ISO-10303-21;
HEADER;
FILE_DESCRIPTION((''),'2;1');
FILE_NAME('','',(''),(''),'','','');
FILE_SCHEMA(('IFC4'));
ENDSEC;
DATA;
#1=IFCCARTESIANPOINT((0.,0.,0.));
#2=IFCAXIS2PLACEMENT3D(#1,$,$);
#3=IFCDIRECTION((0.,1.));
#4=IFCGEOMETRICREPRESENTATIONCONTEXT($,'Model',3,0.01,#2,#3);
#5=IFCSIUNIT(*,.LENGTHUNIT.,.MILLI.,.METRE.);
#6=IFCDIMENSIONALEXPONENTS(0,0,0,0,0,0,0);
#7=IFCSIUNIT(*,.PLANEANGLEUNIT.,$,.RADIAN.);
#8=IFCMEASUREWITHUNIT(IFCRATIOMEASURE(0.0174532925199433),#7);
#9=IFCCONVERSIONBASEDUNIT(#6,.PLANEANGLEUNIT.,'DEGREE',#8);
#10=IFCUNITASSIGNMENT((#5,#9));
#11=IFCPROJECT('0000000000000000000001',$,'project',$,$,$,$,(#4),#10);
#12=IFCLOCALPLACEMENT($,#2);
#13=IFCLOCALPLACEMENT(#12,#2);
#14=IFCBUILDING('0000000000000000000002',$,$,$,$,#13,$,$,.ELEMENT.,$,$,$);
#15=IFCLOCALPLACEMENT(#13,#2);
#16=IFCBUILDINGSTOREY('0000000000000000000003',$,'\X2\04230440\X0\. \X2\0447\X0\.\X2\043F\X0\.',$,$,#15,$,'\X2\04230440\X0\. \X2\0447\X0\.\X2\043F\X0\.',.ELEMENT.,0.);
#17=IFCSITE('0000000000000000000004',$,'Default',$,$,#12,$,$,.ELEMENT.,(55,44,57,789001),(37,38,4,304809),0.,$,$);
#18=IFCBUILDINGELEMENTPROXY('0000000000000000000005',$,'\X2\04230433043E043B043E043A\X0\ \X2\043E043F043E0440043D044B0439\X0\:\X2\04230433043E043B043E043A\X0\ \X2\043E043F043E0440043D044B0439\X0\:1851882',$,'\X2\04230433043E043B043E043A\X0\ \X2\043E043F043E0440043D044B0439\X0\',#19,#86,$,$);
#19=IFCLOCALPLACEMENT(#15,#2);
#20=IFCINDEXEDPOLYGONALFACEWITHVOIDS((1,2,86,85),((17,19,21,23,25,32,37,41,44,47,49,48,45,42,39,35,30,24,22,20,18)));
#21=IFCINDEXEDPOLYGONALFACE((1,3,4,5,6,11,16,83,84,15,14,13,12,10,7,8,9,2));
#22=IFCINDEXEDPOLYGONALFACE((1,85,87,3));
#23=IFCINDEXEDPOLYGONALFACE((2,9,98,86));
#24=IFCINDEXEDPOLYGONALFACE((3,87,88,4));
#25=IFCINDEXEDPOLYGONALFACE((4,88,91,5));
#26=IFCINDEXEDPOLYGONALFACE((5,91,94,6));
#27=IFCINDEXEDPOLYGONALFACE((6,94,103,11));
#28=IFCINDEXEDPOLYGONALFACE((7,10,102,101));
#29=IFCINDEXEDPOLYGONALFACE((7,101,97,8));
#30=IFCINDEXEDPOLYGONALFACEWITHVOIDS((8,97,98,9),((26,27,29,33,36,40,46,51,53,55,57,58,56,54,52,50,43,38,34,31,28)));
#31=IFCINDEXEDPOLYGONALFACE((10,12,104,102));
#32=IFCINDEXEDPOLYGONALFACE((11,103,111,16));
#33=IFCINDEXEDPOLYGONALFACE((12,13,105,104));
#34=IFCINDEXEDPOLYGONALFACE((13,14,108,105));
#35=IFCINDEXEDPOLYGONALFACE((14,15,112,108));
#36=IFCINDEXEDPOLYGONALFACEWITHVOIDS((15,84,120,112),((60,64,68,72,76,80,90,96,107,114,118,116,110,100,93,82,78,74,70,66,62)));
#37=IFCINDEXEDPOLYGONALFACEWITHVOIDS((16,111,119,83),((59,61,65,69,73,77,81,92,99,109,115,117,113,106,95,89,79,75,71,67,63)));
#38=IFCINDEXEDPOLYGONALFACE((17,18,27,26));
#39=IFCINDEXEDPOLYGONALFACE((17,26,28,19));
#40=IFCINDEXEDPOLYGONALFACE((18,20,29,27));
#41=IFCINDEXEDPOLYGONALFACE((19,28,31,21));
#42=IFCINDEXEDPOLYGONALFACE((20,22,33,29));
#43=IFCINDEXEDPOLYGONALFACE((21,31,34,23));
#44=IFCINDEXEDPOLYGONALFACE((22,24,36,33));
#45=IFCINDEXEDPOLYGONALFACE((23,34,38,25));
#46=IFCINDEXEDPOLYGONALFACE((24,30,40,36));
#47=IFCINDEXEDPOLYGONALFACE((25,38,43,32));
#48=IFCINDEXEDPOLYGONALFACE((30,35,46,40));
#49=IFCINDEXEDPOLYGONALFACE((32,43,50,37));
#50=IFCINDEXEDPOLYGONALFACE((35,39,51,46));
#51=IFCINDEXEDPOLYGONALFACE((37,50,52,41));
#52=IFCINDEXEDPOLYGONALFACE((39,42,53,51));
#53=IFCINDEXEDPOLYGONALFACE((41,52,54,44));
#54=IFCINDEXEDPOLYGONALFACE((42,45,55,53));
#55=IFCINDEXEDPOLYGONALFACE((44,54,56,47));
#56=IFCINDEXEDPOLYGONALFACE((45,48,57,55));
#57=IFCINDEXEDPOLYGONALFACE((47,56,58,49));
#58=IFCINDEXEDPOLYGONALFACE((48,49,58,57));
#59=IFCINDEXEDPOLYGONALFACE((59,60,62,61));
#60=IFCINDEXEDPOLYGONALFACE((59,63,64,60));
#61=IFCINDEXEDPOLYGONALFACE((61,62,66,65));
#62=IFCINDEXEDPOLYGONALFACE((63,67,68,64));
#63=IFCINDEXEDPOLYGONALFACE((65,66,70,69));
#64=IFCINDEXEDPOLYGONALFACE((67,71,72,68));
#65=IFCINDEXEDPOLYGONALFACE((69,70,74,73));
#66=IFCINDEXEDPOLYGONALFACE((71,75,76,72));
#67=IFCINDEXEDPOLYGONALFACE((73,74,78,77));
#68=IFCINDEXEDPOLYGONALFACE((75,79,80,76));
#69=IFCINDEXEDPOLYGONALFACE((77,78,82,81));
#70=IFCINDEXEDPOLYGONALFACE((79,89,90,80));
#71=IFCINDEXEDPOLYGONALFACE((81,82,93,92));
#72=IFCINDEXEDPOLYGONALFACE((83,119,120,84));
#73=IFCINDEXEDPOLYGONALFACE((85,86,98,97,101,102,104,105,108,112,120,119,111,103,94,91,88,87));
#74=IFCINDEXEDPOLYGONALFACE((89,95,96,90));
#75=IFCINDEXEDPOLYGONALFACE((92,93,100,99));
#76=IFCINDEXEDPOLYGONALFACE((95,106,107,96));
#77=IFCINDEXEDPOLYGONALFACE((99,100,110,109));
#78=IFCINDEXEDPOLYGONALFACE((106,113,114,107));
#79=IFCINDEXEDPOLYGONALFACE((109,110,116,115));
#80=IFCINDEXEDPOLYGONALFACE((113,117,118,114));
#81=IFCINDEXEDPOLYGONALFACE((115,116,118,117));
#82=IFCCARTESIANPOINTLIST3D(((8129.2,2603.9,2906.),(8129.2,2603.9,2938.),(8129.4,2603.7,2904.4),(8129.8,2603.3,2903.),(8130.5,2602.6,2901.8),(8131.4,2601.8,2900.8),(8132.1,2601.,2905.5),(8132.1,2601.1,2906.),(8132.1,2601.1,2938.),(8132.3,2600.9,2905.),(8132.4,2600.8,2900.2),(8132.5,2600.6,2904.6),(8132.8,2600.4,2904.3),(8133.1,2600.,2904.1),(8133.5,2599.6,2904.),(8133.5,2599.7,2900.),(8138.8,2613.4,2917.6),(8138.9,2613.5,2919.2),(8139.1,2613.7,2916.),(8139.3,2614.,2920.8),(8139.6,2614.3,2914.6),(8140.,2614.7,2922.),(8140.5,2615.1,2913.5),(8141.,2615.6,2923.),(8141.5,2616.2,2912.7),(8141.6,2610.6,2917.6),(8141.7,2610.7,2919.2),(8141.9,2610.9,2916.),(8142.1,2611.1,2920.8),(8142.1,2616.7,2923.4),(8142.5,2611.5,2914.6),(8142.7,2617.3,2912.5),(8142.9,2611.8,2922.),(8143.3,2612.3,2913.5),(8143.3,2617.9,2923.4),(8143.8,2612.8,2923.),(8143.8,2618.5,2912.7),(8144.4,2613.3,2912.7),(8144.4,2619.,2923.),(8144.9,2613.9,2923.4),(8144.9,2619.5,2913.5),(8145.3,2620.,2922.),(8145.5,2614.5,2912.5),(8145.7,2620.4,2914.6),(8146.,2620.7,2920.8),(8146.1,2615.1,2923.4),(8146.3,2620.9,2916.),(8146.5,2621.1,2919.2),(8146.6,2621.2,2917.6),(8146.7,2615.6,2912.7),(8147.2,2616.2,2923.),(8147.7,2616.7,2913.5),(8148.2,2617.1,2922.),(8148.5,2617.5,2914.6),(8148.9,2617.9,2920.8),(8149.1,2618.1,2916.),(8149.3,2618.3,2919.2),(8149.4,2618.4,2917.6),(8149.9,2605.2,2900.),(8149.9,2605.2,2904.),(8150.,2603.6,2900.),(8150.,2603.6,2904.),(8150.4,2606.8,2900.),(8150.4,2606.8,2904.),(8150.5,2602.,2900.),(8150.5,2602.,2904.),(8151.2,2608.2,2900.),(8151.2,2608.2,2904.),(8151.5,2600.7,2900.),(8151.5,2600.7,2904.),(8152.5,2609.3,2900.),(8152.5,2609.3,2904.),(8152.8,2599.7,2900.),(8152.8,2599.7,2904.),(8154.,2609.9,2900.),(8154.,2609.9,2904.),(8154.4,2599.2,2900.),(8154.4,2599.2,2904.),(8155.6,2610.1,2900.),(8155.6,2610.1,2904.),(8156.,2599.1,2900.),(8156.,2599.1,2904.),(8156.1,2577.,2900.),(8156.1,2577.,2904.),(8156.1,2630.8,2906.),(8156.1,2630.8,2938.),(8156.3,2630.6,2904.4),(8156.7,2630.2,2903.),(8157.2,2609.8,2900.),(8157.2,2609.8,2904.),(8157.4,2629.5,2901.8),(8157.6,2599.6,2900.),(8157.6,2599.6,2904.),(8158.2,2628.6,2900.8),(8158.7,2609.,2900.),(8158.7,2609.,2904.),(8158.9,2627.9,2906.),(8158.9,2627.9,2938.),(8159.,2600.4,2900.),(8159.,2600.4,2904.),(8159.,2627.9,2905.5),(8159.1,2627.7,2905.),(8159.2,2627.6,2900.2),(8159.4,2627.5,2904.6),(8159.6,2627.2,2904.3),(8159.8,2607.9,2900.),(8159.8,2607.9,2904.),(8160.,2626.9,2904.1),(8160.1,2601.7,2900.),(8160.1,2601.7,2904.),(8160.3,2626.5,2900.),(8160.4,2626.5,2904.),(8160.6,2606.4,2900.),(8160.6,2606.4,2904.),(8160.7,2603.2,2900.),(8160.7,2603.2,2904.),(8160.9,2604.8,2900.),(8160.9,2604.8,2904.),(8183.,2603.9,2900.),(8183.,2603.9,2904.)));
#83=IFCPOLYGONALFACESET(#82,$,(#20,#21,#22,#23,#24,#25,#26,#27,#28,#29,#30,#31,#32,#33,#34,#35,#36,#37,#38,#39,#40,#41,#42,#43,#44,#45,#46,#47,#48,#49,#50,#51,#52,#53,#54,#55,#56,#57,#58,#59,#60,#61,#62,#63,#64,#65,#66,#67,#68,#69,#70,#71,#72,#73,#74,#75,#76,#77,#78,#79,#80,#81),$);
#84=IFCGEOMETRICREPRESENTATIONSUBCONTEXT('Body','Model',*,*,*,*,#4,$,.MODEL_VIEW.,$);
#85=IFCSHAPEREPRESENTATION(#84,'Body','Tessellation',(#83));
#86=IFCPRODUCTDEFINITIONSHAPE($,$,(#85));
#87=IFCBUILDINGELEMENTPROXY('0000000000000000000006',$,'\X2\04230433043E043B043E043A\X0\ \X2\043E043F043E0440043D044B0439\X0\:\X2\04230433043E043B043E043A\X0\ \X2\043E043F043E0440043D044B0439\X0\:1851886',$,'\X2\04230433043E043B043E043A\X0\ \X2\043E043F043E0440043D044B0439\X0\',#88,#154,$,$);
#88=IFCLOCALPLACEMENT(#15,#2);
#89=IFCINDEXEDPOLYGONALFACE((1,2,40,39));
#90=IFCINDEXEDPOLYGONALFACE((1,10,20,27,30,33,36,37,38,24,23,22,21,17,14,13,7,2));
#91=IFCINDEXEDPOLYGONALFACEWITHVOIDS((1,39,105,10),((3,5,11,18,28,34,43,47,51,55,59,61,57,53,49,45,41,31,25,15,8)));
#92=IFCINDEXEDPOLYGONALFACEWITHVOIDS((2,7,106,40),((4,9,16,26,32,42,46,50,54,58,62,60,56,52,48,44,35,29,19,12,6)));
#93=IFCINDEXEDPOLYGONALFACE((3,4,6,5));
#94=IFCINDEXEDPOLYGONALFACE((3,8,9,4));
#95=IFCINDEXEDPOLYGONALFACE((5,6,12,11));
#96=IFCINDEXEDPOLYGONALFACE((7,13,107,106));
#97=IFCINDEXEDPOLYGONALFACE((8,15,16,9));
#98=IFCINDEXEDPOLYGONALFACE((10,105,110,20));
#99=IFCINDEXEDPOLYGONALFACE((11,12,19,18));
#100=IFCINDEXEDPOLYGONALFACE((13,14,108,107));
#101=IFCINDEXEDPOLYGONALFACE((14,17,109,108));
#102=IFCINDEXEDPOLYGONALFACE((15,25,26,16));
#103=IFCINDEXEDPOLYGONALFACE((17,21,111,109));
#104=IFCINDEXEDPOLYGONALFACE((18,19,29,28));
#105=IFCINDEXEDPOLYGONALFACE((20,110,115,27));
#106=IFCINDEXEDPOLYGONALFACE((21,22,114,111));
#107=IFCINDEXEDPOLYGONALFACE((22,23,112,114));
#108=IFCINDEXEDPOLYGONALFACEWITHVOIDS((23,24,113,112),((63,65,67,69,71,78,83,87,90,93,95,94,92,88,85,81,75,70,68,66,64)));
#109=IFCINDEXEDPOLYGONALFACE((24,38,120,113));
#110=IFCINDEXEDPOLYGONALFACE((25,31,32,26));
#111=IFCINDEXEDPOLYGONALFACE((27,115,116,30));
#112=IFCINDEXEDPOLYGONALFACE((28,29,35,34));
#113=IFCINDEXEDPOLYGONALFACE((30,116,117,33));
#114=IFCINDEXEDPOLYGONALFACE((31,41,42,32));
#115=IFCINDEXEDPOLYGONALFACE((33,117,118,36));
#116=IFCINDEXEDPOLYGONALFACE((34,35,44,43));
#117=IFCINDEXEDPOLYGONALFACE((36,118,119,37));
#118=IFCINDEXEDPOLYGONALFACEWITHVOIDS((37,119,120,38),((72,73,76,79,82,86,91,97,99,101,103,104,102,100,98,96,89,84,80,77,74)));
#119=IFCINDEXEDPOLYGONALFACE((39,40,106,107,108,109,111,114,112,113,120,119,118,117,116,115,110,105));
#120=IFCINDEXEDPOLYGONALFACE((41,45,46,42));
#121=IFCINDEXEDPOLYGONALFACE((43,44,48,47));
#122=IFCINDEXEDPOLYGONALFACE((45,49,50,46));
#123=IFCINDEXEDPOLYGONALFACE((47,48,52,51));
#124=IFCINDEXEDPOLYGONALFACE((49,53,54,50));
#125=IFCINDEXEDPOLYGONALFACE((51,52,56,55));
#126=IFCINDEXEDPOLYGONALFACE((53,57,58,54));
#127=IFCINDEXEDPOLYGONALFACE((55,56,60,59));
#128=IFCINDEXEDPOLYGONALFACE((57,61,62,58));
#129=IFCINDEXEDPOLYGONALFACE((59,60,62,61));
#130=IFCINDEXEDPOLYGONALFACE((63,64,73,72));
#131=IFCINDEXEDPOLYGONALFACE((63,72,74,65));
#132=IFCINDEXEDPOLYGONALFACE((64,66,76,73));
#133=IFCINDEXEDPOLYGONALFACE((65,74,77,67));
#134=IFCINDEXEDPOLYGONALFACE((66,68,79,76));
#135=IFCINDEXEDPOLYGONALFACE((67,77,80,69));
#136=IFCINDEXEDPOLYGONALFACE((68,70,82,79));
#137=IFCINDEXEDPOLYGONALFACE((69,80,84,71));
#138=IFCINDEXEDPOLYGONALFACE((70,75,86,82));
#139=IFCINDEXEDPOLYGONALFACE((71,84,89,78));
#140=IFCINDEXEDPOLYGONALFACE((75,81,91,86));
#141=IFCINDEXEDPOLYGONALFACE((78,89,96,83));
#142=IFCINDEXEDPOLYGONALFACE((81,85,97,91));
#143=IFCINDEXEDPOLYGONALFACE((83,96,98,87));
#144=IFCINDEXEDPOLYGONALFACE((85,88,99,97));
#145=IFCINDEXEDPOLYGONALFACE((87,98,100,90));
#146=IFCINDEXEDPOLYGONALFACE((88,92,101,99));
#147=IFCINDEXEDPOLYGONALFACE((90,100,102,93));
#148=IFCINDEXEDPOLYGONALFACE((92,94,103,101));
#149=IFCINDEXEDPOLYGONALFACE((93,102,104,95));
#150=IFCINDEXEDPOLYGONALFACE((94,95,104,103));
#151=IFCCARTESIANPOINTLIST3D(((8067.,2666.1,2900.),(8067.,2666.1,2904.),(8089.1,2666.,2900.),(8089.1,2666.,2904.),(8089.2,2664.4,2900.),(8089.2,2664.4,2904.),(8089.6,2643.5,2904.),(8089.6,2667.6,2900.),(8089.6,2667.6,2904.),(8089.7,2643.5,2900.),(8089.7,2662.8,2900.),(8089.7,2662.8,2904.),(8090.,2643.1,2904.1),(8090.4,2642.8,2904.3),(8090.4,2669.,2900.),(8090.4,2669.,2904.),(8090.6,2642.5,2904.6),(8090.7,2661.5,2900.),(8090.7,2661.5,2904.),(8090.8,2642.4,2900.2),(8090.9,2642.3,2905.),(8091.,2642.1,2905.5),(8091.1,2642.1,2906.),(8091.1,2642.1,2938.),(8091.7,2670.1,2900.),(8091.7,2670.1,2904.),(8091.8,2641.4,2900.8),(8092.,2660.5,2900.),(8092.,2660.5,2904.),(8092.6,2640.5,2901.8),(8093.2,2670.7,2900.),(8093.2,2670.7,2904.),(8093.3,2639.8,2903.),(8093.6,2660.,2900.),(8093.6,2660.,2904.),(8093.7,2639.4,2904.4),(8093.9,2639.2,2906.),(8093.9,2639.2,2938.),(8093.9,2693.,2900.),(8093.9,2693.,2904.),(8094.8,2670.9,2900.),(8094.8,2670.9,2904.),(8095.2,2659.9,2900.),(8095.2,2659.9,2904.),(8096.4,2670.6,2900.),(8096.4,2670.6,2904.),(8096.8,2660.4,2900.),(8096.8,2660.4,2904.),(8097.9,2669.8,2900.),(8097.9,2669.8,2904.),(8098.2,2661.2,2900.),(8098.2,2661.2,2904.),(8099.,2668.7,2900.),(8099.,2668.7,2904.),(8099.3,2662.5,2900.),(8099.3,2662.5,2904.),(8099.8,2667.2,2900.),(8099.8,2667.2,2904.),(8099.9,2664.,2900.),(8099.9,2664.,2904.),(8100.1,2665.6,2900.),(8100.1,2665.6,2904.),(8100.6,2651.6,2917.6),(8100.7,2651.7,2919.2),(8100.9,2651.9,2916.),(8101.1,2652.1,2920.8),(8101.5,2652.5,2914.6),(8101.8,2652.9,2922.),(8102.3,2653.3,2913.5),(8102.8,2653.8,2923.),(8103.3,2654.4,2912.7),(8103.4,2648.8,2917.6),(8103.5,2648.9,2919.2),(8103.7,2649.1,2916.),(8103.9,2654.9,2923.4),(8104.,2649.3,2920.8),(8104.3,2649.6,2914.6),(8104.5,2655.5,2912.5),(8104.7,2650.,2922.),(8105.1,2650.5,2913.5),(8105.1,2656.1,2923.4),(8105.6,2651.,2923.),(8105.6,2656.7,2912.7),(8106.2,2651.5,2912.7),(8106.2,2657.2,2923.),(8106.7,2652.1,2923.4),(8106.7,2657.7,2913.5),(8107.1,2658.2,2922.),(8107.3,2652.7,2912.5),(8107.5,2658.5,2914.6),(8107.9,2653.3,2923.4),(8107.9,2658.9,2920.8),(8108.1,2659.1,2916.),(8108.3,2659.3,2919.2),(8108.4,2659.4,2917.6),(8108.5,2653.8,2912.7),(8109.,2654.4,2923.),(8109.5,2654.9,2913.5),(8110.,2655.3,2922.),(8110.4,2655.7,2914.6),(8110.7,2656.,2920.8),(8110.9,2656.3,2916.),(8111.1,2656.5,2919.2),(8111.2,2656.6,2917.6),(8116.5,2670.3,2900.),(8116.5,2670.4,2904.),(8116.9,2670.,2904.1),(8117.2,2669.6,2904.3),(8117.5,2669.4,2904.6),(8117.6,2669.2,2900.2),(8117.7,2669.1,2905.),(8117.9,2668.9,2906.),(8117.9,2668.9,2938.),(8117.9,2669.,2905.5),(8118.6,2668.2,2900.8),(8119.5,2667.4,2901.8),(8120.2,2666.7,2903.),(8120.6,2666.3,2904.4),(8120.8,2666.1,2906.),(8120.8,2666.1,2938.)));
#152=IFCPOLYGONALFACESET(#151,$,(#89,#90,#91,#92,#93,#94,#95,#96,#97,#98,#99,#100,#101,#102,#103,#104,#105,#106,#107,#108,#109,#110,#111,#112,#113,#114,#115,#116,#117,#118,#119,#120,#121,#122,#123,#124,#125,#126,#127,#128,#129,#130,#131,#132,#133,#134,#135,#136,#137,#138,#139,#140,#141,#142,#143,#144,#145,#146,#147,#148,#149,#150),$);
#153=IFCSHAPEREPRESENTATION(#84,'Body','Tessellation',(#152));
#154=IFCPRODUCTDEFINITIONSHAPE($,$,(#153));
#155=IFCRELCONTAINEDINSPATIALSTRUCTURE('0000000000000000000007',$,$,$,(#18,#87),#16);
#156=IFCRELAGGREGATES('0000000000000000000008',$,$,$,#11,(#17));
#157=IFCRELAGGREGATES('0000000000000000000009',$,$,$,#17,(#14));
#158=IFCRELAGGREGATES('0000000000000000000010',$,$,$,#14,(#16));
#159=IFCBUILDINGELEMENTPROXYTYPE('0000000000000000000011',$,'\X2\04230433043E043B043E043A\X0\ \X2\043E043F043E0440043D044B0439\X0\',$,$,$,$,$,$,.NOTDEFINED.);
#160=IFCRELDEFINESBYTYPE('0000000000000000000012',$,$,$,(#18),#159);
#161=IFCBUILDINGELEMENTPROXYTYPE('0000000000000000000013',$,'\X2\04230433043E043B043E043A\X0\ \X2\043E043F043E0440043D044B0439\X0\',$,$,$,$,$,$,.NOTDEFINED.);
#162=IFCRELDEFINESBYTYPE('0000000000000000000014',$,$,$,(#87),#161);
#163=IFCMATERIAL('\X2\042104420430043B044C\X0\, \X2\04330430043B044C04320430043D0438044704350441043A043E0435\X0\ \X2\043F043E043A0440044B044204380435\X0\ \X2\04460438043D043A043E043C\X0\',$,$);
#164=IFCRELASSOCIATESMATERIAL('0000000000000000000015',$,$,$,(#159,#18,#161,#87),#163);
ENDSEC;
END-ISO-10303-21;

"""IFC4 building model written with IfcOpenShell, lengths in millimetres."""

from ifc_helpers import new_model, entity, si_unit, converted_unit, direction, frame, frame_2d, origin, place, context, subcontext, project, spatial, polyline, circle_curve, parameter, trimmed, segment, composite_curve, circle, outline, extrude, source, transform, mapped, material, type_object, type_shapes, element, save


model = new_model("IFC4")

# Units and contexts
model_context = context("Model", 3, precision=0.01, world=origin(), true_north=direction((0.0, 1.0)))
body_context = subcontext(model_context, "Body", "Model", "MODEL_VIEW")
ifc_project = project(units=[si_unit("LENGTHUNIT", "METRE", prefix="MILLI"), converted_unit("PLANEANGLEUNIT", "DEGREE", entity("IfcRatioMeasure", 0.0174532925199433), si_unit("PLANEANGLEUNIT", "RADIAN"), dimensions=[0, 0, 0, 0, 0, 0, 0])], contexts=[model_context])

# Site, building, storey
site_placement = place(None, origin())
site = spatial("IfcSite", under=ifc_project, at=site_placement, Name="Default", CompositionType="ELEMENT", RefLatitude=(55, 44, 57, 789001), RefLongitude=(37, 38, 4, 304809), RefElevation=0.0)
building_placement = place(site_placement, origin())
building = spatial("IfcBuilding", under=site, at=building_placement, CompositionType="ELEMENT")
storey_placement = place(building_placement, origin())
storey = spatial("IfcBuildingStorey", under=building, at=storey_placement, Name="Ур. ч.п.", LongName="Ур. ч.п.", CompositionType="ELEMENT", Elevation=0.0)

# Building element proxies, openings
ifc_material_1 = material(Name="Сталь, гальваническое покрытие цинком")
building_element_proxy_type_1 = type_object("IfcBuildingElementProxyType", Name="Уголок опорный", material=ifc_material_1)
shared_shape_1 = source(origin(), body_context, "Body", "SweptSolid", [
    extrude(outline(composite_curve([segment(polyline([(-6.0, -12.0), (26.0, -12.0)]), True, "CONTINUOUS"), segment(polyline([(26.0, -12.0), (26.0, -8.0)]), True, "CONTINUOUS"), segment(polyline([(26.0, -8.0), (-6.0, -8.0)]), True, "CONTINUOUS"), segment(trimmed(circle_curve(frame_2d((-6.0, -6.0), x_axis=(0.0, -1.0)), 2.0), [parameter(270.0)], [parameter(0.0)], True, "PARAMETER"), False, "CONTINUOUS"), segment(polyline([(-8.0, -6.0), (-8.0, 26.0)]), True, "CONTINUOUS"), segment(polyline([(-8.0, 26.0), (-12.0, 26.0)]), True, "CONTINUOUS"), segment(polyline([(-12.0, 26.0), (-12.0, -6.0)]), True, "CONTINUOUS"), segment(trimmed(circle_curve(frame_2d((-6.0, -6.0), x_axis=(0.0, -1.0)), 6.0), [parameter(270.0)], [parameter(360.0)], True, "PARAMETER"), True, "CONTINUOUS")], self_intersect=False)), frame((12.0, -19.0, 12.0), z_axis=(0.0, 1.0, 0.0), x_axis=(0.0, 0.0, 1.0)), (0.0, 0.0, 1.0), 38.0),
])
type_shapes(building_element_proxy_type_1, [shared_shape_1])
proxy_1_placement = place(storey_placement, frame((8142.7, 2617.3, 2900.0), z_axis=(0.0, 0.0, 1.0), x_axis=(0.707107, -0.707107, 0.0)))
proxy_1 = element("IfcBuildingElementProxy", 1, at=proxy_1_placement, inside=storey, type_object=building_element_proxy_type_1, material=ifc_material_1, Name="Уголок опорный:Уголок опорный:1851882", ObjectType="Уголок опорный", context=body_context, shape_type="MappedRepresentation", body=[
    mapped(shared_shape_1, transform((0.0, 0.0, 0.0), scale=1.0)),
])
opening_1_placement = place(storey_placement, frame((8142.7, 2617.3, 2900.0), z_axis=(0.0, 0.0, 1.0), x_axis=(0.0, -1.0, 0.0)))
element("IfcOpeningElement", 2, at=opening_1_placement, cuts=proxy_1, ObjectType="Opening", PredefinedType="OPENING", context=body_context, shape_type="SweptSolid", body=[
    extrude(circle(Radius=5.5, at=frame_2d((0.0, 0.0), x_axis=(1.0, 0.0))), frame((2.8, 2.8, 18.0), z_axis=(-0.707107, -0.707107, 0.0), x_axis=(0.0, 0.0, -1.0)), (0.0, 0.0, 1.0), 4.0),
])
opening_2_placement = place(storey_placement, frame((8142.7, 2617.3, 2900.0), z_axis=(0.0, 0.0, 1.0), x_axis=(0.0, -1.0, 0.0)))
element("IfcOpeningElement", 3, at=opening_2_placement, cuts=proxy_1, ObjectType="Opening", PredefinedType="OPENING", context=body_context, shape_type="SweptSolid", body=[
    extrude(circle(Radius=5.5, at=frame_2d((0.0, 0.0), x_axis=(1.0, 0.0))), frame((12.7, 12.7, 0.0), z_axis=(0.0, 0.0, 1.0), x_axis=(0.707107, -0.707107, 0.0)), (0.0, 0.0, 1.0), 4.0),
])
building_element_proxy_type_2 = type_object("IfcBuildingElementProxyType", Name="Уголок опорный", material=ifc_material_1)
shared_shape_2 = source(origin(), body_context, "Body", "SweptSolid", [
    extrude(outline(composite_curve([segment(polyline([(-6.0, -12.0), (26.0, -12.0)]), True, "CONTINUOUS"), segment(polyline([(26.0, -12.0), (26.0, -8.0)]), True, "CONTINUOUS"), segment(polyline([(26.0, -8.0), (-6.0, -8.0)]), True, "CONTINUOUS"), segment(trimmed(circle_curve(frame_2d((-6.0, -6.0), x_axis=(0.0, -1.0)), 2.0), [parameter(270.0)], [parameter(0.0)], True, "PARAMETER"), False, "CONTINUOUS"), segment(polyline([(-8.0, -6.0), (-8.0, 26.0)]), True, "CONTINUOUS"), segment(polyline([(-8.0, 26.0), (-12.0, 26.0)]), True, "CONTINUOUS"), segment(polyline([(-12.0, 26.0), (-12.0, -6.0)]), True, "CONTINUOUS"), segment(trimmed(circle_curve(frame_2d((-6.0, -6.0), x_axis=(0.0, -1.0)), 6.0), [parameter(270.0)], [parameter(360.0)], True, "PARAMETER"), True, "CONTINUOUS")], self_intersect=False)), frame((12.0, -19.0, 12.0), z_axis=(0.0, 1.0, 0.0), x_axis=(0.0, 0.0, 1.0)), (0.0, 0.0, 1.0), 38.0),
])
type_shapes(building_element_proxy_type_2, [shared_shape_2])
proxy_2_placement = place(storey_placement, frame((8107.3, 2652.7, 2900.0), z_axis=(0.0, 0.0, 1.0), x_axis=(-0.707107, 0.707107, 0.0)))
proxy_2 = element("IfcBuildingElementProxy", 4, at=proxy_2_placement, inside=storey, type_object=building_element_proxy_type_2, material=ifc_material_1, Name="Уголок опорный:Уголок опорный:1851886", ObjectType="Уголок опорный", context=body_context, shape_type="MappedRepresentation", body=[
    mapped(shared_shape_2, transform((0.0, 0.0, 0.0), scale=1.0)),
])
opening_3_placement = place(storey_placement, frame((8107.3, 2652.7, 2900.0), z_axis=(0.0, 0.0, 1.0), x_axis=(0.0, -1.0, 0.0)))
element("IfcOpeningElement", 5, at=opening_3_placement, cuts=proxy_2, ObjectType="Opening", PredefinedType="OPENING", context=body_context, shape_type="SweptSolid", body=[
    extrude(circle(Radius=5.5, at=frame_2d((0.0, 0.0), x_axis=(1.0, 0.0))), frame((0.0, 0.0, 18.0), z_axis=(-0.707107, -0.707107, 0.0), x_axis=(0.0, 0.0, -1.0)), (0.0, 0.0, 1.0), 4.0),
])
opening_4_placement = place(storey_placement, frame((8107.3, 2652.7, 2900.0), z_axis=(0.0, 0.0, 1.0), x_axis=(0.0, -1.0, 0.0)))
element("IfcOpeningElement", 6, at=opening_4_placement, cuts=proxy_2, ObjectType="Opening", PredefinedType="OPENING", context=body_context, shape_type="SweptSolid", body=[
    extrude(circle(Radius=5.5, at=frame_2d((0.0, 0.0), x_axis=(1.0, 0.0))), frame((-12.7, -12.7, 0.0), z_axis=(0.0, 0.0, 1.0), x_axis=(0.707107, -0.707107, 0.0)), (0.0, 0.0, 1.0), 4.0),
])

save(model, "model.ifc")
